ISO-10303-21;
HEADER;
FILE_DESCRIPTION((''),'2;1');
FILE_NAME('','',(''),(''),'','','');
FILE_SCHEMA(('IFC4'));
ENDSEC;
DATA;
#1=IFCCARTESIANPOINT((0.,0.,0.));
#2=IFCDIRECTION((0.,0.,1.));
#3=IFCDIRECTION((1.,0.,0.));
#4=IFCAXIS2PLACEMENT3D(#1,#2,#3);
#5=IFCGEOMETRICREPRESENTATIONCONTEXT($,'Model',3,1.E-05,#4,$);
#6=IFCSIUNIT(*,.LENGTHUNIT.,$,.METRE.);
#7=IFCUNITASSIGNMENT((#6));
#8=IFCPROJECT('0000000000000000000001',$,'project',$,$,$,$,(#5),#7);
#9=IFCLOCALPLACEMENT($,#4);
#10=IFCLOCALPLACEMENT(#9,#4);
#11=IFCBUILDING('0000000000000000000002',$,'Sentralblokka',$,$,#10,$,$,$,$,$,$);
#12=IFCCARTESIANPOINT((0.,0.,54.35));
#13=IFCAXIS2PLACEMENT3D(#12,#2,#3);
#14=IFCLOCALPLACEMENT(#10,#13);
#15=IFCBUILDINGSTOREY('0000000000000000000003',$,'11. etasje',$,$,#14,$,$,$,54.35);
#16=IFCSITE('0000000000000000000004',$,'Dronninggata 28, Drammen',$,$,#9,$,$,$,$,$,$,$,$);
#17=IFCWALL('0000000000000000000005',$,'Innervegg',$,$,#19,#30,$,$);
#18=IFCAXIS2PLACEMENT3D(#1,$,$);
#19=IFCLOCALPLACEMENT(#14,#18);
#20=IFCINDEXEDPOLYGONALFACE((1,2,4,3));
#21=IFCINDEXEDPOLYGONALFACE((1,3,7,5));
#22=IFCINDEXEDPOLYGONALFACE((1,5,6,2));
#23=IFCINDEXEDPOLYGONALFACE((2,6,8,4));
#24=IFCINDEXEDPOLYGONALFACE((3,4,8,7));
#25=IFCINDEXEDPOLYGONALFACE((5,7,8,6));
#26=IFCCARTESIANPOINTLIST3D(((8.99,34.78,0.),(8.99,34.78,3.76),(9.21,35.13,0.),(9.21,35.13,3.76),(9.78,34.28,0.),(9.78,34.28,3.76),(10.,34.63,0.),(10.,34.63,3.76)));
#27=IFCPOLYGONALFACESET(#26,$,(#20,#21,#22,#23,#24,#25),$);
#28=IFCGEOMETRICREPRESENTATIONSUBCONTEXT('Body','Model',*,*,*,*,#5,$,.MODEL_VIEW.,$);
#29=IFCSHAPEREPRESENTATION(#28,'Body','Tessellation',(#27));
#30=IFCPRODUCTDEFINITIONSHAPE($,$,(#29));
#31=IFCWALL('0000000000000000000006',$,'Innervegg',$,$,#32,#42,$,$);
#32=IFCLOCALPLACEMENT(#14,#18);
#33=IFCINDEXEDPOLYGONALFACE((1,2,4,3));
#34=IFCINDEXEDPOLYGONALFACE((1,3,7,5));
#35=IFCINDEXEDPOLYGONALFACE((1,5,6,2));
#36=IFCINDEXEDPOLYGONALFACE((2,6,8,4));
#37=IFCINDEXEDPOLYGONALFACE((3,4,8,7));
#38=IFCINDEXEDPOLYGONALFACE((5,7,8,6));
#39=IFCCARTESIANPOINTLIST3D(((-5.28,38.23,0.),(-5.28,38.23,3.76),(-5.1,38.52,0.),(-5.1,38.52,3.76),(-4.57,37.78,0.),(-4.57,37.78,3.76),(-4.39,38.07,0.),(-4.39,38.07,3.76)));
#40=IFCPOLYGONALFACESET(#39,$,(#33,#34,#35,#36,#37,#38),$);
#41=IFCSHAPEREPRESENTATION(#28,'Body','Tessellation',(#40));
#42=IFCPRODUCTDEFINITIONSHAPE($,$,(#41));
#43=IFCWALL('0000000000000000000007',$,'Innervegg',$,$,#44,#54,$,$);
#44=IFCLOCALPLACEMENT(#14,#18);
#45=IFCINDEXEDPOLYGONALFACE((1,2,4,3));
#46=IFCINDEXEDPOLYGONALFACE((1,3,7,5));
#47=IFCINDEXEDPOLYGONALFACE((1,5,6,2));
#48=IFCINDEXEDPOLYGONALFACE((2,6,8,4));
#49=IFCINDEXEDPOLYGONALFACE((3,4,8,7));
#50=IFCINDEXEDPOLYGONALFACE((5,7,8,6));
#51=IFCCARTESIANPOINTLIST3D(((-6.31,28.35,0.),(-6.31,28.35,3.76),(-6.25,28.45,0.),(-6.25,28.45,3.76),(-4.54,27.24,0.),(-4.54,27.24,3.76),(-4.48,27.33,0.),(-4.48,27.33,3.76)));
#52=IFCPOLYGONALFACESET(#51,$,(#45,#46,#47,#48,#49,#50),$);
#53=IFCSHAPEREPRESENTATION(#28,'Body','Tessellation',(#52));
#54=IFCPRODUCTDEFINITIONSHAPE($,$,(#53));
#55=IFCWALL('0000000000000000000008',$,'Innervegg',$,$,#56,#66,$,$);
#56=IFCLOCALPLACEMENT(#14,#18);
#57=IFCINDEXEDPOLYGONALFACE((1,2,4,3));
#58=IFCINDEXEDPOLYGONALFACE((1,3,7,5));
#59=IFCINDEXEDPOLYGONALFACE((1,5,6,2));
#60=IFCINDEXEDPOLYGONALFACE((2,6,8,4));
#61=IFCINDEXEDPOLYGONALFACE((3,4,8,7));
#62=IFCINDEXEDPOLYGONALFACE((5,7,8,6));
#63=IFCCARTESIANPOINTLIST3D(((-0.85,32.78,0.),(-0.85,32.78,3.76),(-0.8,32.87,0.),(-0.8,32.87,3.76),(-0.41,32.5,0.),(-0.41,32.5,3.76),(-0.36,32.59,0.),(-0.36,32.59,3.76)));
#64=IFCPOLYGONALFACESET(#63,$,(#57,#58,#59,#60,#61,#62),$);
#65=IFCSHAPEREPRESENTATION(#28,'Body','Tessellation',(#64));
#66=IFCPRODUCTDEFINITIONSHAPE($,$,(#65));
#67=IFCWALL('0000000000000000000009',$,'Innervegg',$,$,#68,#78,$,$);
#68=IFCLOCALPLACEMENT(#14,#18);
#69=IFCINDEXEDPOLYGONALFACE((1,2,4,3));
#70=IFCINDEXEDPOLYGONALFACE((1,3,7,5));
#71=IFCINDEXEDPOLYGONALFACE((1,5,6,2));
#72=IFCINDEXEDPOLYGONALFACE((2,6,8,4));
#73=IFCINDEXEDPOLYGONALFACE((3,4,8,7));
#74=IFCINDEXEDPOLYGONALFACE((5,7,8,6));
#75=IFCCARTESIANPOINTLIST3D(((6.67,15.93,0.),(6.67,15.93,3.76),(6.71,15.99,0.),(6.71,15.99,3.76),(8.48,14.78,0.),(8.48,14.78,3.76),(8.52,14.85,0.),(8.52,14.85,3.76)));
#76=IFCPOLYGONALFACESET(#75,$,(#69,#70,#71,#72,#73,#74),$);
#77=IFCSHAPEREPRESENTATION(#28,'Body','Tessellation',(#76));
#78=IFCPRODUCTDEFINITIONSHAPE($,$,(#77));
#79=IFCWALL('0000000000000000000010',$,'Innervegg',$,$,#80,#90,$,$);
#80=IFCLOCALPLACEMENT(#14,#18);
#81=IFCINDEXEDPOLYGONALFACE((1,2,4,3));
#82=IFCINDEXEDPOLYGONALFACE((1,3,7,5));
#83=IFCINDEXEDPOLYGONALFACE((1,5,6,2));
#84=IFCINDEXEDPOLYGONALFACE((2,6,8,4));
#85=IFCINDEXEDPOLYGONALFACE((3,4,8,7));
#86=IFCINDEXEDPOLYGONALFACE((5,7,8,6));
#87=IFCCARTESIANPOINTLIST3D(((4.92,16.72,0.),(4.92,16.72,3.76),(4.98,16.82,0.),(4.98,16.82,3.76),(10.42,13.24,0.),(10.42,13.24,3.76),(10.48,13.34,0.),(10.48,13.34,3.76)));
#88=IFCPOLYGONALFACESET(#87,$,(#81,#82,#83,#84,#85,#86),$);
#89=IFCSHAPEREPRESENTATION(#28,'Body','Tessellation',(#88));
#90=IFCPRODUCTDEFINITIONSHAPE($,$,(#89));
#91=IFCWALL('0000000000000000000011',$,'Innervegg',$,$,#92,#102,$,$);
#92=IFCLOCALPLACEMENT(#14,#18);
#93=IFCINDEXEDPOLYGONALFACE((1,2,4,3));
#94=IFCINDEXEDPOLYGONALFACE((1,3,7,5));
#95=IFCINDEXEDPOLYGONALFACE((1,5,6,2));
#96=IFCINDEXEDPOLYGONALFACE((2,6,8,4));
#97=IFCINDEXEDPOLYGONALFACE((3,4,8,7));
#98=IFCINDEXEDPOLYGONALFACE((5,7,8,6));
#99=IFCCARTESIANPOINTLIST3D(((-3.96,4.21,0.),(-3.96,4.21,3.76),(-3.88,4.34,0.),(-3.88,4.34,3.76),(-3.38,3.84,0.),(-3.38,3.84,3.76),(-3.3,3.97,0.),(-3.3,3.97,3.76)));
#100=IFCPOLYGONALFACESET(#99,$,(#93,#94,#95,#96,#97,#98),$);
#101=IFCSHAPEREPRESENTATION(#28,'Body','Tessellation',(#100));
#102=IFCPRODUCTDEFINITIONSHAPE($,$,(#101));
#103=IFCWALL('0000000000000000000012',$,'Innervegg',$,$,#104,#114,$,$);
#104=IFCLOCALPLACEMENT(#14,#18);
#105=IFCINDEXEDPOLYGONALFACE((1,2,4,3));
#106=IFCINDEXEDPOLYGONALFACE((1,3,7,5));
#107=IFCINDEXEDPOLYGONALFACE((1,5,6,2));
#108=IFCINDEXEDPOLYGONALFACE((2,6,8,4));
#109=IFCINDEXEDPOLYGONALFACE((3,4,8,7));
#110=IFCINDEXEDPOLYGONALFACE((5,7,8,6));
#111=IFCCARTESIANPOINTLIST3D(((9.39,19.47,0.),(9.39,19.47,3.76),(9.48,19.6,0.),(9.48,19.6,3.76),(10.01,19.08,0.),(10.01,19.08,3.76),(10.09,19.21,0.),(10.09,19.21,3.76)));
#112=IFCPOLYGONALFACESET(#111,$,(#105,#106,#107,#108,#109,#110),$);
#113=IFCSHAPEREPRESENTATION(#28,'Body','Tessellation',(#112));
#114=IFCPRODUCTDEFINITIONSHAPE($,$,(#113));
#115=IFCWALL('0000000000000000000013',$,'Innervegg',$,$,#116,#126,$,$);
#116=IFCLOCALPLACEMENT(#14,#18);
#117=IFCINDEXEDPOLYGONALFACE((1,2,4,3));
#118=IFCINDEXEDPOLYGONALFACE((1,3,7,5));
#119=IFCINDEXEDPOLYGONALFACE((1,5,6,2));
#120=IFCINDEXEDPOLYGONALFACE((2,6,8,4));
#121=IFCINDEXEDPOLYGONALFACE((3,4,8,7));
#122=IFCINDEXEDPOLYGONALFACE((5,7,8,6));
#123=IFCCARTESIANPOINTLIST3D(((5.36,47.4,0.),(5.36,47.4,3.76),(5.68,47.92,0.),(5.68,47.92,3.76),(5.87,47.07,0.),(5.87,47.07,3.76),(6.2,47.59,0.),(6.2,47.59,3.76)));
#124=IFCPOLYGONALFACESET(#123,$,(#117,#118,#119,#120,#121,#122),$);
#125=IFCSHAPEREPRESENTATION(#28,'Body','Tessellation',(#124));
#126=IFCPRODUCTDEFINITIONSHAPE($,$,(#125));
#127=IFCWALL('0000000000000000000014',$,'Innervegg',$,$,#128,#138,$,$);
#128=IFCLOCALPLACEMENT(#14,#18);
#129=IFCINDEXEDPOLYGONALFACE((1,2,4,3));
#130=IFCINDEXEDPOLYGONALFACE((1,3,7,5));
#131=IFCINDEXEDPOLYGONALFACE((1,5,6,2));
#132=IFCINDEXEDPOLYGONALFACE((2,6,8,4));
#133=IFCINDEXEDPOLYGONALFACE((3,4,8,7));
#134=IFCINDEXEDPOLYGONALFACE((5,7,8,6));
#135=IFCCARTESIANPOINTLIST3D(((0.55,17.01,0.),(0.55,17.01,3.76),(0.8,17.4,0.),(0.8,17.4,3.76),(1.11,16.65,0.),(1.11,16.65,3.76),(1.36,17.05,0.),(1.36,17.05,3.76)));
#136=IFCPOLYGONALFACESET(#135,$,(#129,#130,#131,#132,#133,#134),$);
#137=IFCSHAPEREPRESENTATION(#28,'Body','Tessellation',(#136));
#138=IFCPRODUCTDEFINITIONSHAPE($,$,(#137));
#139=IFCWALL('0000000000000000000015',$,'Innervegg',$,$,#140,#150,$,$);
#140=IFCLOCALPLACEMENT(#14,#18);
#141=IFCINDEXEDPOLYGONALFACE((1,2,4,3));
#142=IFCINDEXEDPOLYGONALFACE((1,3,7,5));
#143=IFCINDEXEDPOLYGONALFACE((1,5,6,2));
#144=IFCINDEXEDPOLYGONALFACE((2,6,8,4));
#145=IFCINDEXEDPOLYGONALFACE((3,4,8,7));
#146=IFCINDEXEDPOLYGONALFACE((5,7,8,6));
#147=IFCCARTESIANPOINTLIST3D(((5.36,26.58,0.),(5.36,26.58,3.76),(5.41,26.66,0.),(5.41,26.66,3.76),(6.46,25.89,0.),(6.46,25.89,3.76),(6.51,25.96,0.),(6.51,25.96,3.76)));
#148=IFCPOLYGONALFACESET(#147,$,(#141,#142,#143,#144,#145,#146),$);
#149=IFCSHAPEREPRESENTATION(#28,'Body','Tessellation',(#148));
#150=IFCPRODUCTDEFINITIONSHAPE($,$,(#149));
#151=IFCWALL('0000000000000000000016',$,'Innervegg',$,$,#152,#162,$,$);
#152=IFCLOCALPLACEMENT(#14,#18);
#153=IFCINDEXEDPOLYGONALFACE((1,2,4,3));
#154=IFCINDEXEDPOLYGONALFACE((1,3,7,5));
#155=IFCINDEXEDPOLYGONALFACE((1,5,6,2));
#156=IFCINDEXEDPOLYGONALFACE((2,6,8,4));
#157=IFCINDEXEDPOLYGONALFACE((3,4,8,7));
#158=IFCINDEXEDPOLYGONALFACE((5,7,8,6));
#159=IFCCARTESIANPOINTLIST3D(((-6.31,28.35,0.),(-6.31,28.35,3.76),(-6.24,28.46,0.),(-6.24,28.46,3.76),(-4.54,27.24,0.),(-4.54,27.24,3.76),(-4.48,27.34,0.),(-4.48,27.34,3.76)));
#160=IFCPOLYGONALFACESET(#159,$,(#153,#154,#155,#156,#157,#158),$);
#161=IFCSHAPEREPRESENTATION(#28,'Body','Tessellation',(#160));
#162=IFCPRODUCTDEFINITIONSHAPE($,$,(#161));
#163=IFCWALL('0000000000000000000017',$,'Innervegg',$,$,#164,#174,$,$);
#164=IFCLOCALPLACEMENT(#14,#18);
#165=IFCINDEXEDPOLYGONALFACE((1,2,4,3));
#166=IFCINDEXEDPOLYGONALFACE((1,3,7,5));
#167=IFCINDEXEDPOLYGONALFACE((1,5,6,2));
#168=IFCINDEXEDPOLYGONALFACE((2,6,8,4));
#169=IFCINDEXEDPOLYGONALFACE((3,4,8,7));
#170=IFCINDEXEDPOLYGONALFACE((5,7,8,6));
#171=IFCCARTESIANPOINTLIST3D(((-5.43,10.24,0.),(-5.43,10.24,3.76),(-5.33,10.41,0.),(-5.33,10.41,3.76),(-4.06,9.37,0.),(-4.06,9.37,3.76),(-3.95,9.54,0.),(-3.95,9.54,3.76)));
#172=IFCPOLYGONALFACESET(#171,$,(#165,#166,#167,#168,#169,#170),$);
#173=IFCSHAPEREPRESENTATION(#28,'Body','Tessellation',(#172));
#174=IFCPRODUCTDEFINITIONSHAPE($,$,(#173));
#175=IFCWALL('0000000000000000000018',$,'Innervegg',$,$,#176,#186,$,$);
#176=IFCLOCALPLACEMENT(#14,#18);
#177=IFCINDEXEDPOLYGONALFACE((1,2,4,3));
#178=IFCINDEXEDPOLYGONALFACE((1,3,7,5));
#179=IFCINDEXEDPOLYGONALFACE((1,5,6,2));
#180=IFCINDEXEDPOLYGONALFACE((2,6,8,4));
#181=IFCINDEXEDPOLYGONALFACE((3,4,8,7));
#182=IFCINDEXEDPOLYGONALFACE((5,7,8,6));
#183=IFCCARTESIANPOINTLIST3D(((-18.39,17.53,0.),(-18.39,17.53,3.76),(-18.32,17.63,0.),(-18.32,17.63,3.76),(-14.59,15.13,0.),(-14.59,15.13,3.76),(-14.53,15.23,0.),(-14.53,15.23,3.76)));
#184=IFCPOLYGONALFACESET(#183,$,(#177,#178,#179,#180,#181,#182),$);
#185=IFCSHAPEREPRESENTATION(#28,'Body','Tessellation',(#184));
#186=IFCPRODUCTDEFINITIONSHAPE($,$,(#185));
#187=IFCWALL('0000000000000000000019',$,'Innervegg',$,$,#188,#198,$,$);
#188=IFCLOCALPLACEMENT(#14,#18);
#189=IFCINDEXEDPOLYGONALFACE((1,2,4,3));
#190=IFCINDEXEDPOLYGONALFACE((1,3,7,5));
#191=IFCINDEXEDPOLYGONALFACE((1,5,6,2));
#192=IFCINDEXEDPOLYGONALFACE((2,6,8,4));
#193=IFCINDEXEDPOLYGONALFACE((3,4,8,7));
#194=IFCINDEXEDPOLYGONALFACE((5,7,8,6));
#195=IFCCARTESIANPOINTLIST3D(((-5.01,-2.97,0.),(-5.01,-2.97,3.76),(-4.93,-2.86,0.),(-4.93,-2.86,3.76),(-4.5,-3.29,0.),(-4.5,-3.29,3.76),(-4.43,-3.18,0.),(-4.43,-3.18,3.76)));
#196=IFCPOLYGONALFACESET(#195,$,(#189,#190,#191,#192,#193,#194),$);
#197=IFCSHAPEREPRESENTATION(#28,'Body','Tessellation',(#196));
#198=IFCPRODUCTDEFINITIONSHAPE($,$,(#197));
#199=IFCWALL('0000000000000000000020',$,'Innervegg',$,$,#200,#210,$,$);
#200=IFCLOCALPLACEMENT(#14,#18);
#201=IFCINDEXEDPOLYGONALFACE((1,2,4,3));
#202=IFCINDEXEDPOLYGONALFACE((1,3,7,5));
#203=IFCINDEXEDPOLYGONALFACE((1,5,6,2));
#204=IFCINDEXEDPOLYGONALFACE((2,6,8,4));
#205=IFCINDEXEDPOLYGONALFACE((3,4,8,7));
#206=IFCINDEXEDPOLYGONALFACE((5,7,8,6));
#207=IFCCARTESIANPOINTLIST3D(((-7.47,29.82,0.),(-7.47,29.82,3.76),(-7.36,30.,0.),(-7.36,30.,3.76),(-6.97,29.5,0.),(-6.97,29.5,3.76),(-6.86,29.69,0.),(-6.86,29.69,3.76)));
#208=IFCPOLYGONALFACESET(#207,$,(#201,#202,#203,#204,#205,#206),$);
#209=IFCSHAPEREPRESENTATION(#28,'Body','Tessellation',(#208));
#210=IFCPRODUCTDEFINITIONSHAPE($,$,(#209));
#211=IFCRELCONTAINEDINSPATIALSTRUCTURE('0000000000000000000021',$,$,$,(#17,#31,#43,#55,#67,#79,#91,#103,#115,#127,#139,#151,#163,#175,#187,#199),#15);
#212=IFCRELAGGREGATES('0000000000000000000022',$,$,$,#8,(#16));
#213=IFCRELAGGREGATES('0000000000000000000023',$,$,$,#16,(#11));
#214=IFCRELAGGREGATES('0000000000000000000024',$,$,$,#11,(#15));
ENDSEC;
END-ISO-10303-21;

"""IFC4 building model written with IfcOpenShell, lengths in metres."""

from ifc_helpers import new_model, si_unit, frame, origin_with_axes, place, context, subcontext, project, spatial, polyline, outline, extrude, element, save


model = new_model("IFC4")

# Units and contexts
model_context = context("Model", 3, precision=1e-05, world=origin_with_axes())
body_context = subcontext(model_context, "Body", "Model", "MODEL_VIEW")
ifc_project = project(units=[si_unit("LENGTHUNIT", "METRE")], contexts=[model_context])

# Site, building, storey
site_placement = place(None, origin_with_axes())
site = spatial("IfcSite", under=ifc_project, at=site_placement, Name="Dronninggata 28, Drammen")
building_placement = place(site_placement, origin_with_axes())
building = spatial("IfcBuilding", under=site, at=building_placement, Name="Sentralblokka")
storey_placement = place(building_placement, frame((0.0, 0.0, 54.35), z_axis=(0.0, 0.0, 1.0), x_axis=(1.0, 0.0, 0.0)))
storey = spatial("IfcBuildingStorey", under=building, at=storey_placement, Name="11. etasje", Elevation=54.35)

# Walls
wall_1_placement = place(storey_placement, frame((0.0, 0.0, -54.35), z_axis=(0.0, 0.0, 1.0), x_axis=(1.0, 0.0, 0.0)))
element("IfcWall", 1, at=wall_1_placement, inside=storey, Name="Innervegg", context=body_context, shape_type="SweptSolid", body=[
    extrude(outline(polyline([(10.0, 34.63), (9.78, 34.28), (8.99, 34.78), (9.21, 35.13), (10.0, 34.63)])), frame((0.0, 0.0, 54.35)), (0.0, 0.0, 1.0), 3.76),
])
wall_2_placement = place(storey_placement, frame((0.0, 0.0, -54.35), z_axis=(0.0, 0.0, 1.0), x_axis=(1.0, 0.0, 0.0)))
element("IfcWall", 2, at=wall_2_placement, inside=storey, Name="Innervegg", context=body_context, shape_type="SweptSolid", body=[
    extrude(outline(polyline([(-4.39, 38.07), (-4.57, 37.78), (-5.28, 38.23), (-5.1, 38.52), (-4.39, 38.07)])), frame((0.0, 0.0, 54.35)), (0.0, 0.0, 1.0), 3.76),
])
wall_3_placement = place(storey_placement, frame((0.0, 0.0, -54.35), z_axis=(0.0, 0.0, 1.0), x_axis=(1.0, 0.0, 0.0)))
element("IfcWall", 3, at=wall_3_placement, inside=storey, Name="Innervegg", context=body_context, shape_type="SweptSolid", body=[
    extrude(outline(polyline([(-4.48, 27.33), (-4.54, 27.24), (-6.31, 28.35), (-6.25, 28.45), (-4.48, 27.33)])), frame((0.0, 0.0, 54.35)), (0.0, 0.0, 1.0), 3.76),
])
wall_4_placement = place(storey_placement, frame((0.0, 0.0, -54.35), z_axis=(0.0, 0.0, 1.0), x_axis=(1.0, 0.0, 0.0)))
element("IfcWall", 4, at=wall_4_placement, inside=storey, Name="Innervegg", context=body_context, shape_type="SweptSolid", body=[
    extrude(outline(polyline([(-0.36, 32.59), (-0.41, 32.5), (-0.85, 32.78), (-0.8, 32.87), (-0.36, 32.59)])), frame((0.0, 0.0, 54.35)), (0.0, 0.0, 1.0), 3.76),
])
wall_5_placement = place(storey_placement, frame((0.0, 0.0, -54.35), z_axis=(0.0, 0.0, 1.0), x_axis=(1.0, 0.0, 0.0)))
element("IfcWall", 5, at=wall_5_placement, inside=storey, Name="Innervegg", context=body_context, shape_type="SweptSolid", body=[
    extrude(outline(polyline([(8.52, 14.85), (8.48, 14.78), (6.67, 15.93), (6.71, 15.99), (8.52, 14.85)])), frame((0.0, 0.0, 54.35)), (0.0, 0.0, 1.0), 3.76),
])
wall_6_placement = place(storey_placement, frame((0.0, 0.0, -54.35), z_axis=(0.0, 0.0, 1.0), x_axis=(1.0, 0.0, 0.0)))
element("IfcWall", 6, at=wall_6_placement, inside=storey, Name="Innervegg", context=body_context, shape_type="SweptSolid", body=[
    extrude(outline(polyline([(10.48, 13.34), (10.42, 13.24), (4.92, 16.72), (4.98, 16.82), (10.48, 13.34)])), frame((0.0, 0.0, 54.35)), (0.0, 0.0, 1.0), 3.76),
])
wall_7_placement = place(storey_placement, frame((0.0, 0.0, -54.35), z_axis=(0.0, 0.0, 1.0), x_axis=(1.0, 0.0, 0.0)))
element("IfcWall", 7, at=wall_7_placement, inside=storey, Name="Innervegg", context=body_context, shape_type="SweptSolid", body=[
    extrude(outline(polyline([(-3.3, 3.97), (-3.38, 3.84), (-3.96, 4.21), (-3.88, 4.34), (-3.3, 3.97)])), frame((0.0, 0.0, 54.35)), (0.0, 0.0, 1.0), 3.76),
])
wall_8_placement = place(storey_placement, frame((0.0, 0.0, -54.35), z_axis=(0.0, 0.0, 1.0), x_axis=(1.0, 0.0, 0.0)))
element("IfcWall", 8, at=wall_8_placement, inside=storey, Name="Innervegg", context=body_context, shape_type="SweptSolid", body=[
    extrude(outline(polyline([(10.09, 19.21), (10.01, 19.08), (9.39, 19.47), (9.48, 19.6), (10.09, 19.21)])), frame((0.0, 0.0, 54.35)), (0.0, 0.0, 1.0), 3.76),
])
wall_9_placement = place(storey_placement, frame((0.0, 0.0, -54.35), z_axis=(0.0, 0.0, 1.0), x_axis=(1.0, 0.0, 0.0)))
element("IfcWall", 9, at=wall_9_placement, inside=storey, Name="Innervegg", context=body_context, shape_type="SweptSolid", body=[
    extrude(outline(polyline([(6.2, 47.59), (5.87, 47.07), (5.36, 47.4), (5.68, 47.92), (6.2, 47.59)])), frame((0.0, 0.0, 54.35)), (0.0, 0.0, 1.0), 3.76),
])
wall_10_placement = place(storey_placement, frame((0.0, 0.0, -54.35), z_axis=(0.0, 0.0, 1.0), x_axis=(1.0, 0.0, 0.0)))
element("IfcWall", 10, at=wall_10_placement, inside=storey, Name="Innervegg", context=body_context, shape_type="SweptSolid", body=[
    extrude(outline(polyline([(1.36, 17.05), (1.11, 16.65), (0.55, 17.01), (0.8, 17.4), (1.36, 17.05)])), frame((0.0, 0.0, 54.35)), (0.0, 0.0, 1.0), 3.76),
])
wall_11_placement = place(storey_placement, frame((0.0, 0.0, -54.35), z_axis=(0.0, 0.0, 1.0), x_axis=(1.0, 0.0, 0.0)))
element("IfcWall", 11, at=wall_11_placement, inside=storey, Name="Innervegg", context=body_context, shape_type="SweptSolid", body=[
    extrude(outline(polyline([(6.51, 25.96), (6.46, 25.89), (5.36, 26.58), (5.41, 26.66), (6.51, 25.96)])), frame((0.0, 0.0, 54.35)), (0.0, 0.0, 1.0), 3.76),
])
wall_12_placement = place(storey_placement, frame((0.0, 0.0, -54.35), z_axis=(0.0, 0.0, 1.0), x_axis=(1.0, 0.0, 0.0)))
element("IfcWall", 12, at=wall_12_placement, inside=storey, Name="Innervegg", context=body_context, shape_type="SweptSolid", body=[
    extrude(outline(polyline([(-4.48, 27.34), (-4.54, 27.24), (-6.31, 28.35), (-6.24, 28.46), (-4.48, 27.34)])), frame((0.0, 0.0, 54.35)), (0.0, 0.0, 1.0), 3.76),
])
wall_13_placement = place(storey_placement, frame((0.0, 0.0, -54.35), z_axis=(0.0, 0.0, 1.0), x_axis=(1.0, 0.0, 0.0)))
element("IfcWall", 13, at=wall_13_placement, inside=storey, Name="Innervegg", context=body_context, shape_type="SweptSolid", body=[
    extrude(outline(polyline([(-3.95, 9.54), (-4.06, 9.37), (-5.43, 10.24), (-5.33, 10.41), (-3.95, 9.54)])), frame((0.0, 0.0, 54.35)), (0.0, 0.0, 1.0), 3.76),
])
wall_14_placement = place(storey_placement, frame((0.0, 0.0, -54.35), z_axis=(0.0, 0.0, 1.0), x_axis=(1.0, 0.0, 0.0)))
element("IfcWall", 14, at=wall_14_placement, inside=storey, Name="Innervegg", context=body_context, shape_type="SweptSolid", body=[
    extrude(outline(polyline([(-14.53, 15.23), (-14.59, 15.13), (-18.39, 17.53), (-18.32, 17.63), (-14.53, 15.23)])), frame((0.0, 0.0, 54.35)), (0.0, 0.0, 1.0), 3.76),
])
wall_15_placement = place(storey_placement, frame((0.0, 0.0, -54.35), z_axis=(0.0, 0.0, 1.0), x_axis=(1.0, 0.0, 0.0)))
element("IfcWall", 15, at=wall_15_placement, inside=storey, Name="Innervegg", context=body_context, shape_type="SweptSolid", body=[
    extrude(outline(polyline([(-4.43, -3.18), (-4.5, -3.29), (-5.01, -2.97), (-4.93, -2.86), (-4.43, -3.18)])), frame((0.0, 0.0, 54.35)), (0.0, 0.0, 1.0), 3.76),
])
wall_16_placement = place(storey_placement, frame((0.0, 0.0, -54.35), z_axis=(0.0, 0.0, 1.0), x_axis=(1.0, 0.0, 0.0)))
element("IfcWall", 16, at=wall_16_placement, inside=storey, Name="Innervegg", context=body_context, shape_type="SweptSolid", body=[
    extrude(outline(polyline([(-6.86, 29.69), (-6.97, 29.5), (-7.47, 29.82), (-7.36, 30.0), (-6.86, 29.69)])), frame((0.0, 0.0, 54.35)), (0.0, 0.0, 1.0), 3.76),
])

save(model, "model.ifc")
